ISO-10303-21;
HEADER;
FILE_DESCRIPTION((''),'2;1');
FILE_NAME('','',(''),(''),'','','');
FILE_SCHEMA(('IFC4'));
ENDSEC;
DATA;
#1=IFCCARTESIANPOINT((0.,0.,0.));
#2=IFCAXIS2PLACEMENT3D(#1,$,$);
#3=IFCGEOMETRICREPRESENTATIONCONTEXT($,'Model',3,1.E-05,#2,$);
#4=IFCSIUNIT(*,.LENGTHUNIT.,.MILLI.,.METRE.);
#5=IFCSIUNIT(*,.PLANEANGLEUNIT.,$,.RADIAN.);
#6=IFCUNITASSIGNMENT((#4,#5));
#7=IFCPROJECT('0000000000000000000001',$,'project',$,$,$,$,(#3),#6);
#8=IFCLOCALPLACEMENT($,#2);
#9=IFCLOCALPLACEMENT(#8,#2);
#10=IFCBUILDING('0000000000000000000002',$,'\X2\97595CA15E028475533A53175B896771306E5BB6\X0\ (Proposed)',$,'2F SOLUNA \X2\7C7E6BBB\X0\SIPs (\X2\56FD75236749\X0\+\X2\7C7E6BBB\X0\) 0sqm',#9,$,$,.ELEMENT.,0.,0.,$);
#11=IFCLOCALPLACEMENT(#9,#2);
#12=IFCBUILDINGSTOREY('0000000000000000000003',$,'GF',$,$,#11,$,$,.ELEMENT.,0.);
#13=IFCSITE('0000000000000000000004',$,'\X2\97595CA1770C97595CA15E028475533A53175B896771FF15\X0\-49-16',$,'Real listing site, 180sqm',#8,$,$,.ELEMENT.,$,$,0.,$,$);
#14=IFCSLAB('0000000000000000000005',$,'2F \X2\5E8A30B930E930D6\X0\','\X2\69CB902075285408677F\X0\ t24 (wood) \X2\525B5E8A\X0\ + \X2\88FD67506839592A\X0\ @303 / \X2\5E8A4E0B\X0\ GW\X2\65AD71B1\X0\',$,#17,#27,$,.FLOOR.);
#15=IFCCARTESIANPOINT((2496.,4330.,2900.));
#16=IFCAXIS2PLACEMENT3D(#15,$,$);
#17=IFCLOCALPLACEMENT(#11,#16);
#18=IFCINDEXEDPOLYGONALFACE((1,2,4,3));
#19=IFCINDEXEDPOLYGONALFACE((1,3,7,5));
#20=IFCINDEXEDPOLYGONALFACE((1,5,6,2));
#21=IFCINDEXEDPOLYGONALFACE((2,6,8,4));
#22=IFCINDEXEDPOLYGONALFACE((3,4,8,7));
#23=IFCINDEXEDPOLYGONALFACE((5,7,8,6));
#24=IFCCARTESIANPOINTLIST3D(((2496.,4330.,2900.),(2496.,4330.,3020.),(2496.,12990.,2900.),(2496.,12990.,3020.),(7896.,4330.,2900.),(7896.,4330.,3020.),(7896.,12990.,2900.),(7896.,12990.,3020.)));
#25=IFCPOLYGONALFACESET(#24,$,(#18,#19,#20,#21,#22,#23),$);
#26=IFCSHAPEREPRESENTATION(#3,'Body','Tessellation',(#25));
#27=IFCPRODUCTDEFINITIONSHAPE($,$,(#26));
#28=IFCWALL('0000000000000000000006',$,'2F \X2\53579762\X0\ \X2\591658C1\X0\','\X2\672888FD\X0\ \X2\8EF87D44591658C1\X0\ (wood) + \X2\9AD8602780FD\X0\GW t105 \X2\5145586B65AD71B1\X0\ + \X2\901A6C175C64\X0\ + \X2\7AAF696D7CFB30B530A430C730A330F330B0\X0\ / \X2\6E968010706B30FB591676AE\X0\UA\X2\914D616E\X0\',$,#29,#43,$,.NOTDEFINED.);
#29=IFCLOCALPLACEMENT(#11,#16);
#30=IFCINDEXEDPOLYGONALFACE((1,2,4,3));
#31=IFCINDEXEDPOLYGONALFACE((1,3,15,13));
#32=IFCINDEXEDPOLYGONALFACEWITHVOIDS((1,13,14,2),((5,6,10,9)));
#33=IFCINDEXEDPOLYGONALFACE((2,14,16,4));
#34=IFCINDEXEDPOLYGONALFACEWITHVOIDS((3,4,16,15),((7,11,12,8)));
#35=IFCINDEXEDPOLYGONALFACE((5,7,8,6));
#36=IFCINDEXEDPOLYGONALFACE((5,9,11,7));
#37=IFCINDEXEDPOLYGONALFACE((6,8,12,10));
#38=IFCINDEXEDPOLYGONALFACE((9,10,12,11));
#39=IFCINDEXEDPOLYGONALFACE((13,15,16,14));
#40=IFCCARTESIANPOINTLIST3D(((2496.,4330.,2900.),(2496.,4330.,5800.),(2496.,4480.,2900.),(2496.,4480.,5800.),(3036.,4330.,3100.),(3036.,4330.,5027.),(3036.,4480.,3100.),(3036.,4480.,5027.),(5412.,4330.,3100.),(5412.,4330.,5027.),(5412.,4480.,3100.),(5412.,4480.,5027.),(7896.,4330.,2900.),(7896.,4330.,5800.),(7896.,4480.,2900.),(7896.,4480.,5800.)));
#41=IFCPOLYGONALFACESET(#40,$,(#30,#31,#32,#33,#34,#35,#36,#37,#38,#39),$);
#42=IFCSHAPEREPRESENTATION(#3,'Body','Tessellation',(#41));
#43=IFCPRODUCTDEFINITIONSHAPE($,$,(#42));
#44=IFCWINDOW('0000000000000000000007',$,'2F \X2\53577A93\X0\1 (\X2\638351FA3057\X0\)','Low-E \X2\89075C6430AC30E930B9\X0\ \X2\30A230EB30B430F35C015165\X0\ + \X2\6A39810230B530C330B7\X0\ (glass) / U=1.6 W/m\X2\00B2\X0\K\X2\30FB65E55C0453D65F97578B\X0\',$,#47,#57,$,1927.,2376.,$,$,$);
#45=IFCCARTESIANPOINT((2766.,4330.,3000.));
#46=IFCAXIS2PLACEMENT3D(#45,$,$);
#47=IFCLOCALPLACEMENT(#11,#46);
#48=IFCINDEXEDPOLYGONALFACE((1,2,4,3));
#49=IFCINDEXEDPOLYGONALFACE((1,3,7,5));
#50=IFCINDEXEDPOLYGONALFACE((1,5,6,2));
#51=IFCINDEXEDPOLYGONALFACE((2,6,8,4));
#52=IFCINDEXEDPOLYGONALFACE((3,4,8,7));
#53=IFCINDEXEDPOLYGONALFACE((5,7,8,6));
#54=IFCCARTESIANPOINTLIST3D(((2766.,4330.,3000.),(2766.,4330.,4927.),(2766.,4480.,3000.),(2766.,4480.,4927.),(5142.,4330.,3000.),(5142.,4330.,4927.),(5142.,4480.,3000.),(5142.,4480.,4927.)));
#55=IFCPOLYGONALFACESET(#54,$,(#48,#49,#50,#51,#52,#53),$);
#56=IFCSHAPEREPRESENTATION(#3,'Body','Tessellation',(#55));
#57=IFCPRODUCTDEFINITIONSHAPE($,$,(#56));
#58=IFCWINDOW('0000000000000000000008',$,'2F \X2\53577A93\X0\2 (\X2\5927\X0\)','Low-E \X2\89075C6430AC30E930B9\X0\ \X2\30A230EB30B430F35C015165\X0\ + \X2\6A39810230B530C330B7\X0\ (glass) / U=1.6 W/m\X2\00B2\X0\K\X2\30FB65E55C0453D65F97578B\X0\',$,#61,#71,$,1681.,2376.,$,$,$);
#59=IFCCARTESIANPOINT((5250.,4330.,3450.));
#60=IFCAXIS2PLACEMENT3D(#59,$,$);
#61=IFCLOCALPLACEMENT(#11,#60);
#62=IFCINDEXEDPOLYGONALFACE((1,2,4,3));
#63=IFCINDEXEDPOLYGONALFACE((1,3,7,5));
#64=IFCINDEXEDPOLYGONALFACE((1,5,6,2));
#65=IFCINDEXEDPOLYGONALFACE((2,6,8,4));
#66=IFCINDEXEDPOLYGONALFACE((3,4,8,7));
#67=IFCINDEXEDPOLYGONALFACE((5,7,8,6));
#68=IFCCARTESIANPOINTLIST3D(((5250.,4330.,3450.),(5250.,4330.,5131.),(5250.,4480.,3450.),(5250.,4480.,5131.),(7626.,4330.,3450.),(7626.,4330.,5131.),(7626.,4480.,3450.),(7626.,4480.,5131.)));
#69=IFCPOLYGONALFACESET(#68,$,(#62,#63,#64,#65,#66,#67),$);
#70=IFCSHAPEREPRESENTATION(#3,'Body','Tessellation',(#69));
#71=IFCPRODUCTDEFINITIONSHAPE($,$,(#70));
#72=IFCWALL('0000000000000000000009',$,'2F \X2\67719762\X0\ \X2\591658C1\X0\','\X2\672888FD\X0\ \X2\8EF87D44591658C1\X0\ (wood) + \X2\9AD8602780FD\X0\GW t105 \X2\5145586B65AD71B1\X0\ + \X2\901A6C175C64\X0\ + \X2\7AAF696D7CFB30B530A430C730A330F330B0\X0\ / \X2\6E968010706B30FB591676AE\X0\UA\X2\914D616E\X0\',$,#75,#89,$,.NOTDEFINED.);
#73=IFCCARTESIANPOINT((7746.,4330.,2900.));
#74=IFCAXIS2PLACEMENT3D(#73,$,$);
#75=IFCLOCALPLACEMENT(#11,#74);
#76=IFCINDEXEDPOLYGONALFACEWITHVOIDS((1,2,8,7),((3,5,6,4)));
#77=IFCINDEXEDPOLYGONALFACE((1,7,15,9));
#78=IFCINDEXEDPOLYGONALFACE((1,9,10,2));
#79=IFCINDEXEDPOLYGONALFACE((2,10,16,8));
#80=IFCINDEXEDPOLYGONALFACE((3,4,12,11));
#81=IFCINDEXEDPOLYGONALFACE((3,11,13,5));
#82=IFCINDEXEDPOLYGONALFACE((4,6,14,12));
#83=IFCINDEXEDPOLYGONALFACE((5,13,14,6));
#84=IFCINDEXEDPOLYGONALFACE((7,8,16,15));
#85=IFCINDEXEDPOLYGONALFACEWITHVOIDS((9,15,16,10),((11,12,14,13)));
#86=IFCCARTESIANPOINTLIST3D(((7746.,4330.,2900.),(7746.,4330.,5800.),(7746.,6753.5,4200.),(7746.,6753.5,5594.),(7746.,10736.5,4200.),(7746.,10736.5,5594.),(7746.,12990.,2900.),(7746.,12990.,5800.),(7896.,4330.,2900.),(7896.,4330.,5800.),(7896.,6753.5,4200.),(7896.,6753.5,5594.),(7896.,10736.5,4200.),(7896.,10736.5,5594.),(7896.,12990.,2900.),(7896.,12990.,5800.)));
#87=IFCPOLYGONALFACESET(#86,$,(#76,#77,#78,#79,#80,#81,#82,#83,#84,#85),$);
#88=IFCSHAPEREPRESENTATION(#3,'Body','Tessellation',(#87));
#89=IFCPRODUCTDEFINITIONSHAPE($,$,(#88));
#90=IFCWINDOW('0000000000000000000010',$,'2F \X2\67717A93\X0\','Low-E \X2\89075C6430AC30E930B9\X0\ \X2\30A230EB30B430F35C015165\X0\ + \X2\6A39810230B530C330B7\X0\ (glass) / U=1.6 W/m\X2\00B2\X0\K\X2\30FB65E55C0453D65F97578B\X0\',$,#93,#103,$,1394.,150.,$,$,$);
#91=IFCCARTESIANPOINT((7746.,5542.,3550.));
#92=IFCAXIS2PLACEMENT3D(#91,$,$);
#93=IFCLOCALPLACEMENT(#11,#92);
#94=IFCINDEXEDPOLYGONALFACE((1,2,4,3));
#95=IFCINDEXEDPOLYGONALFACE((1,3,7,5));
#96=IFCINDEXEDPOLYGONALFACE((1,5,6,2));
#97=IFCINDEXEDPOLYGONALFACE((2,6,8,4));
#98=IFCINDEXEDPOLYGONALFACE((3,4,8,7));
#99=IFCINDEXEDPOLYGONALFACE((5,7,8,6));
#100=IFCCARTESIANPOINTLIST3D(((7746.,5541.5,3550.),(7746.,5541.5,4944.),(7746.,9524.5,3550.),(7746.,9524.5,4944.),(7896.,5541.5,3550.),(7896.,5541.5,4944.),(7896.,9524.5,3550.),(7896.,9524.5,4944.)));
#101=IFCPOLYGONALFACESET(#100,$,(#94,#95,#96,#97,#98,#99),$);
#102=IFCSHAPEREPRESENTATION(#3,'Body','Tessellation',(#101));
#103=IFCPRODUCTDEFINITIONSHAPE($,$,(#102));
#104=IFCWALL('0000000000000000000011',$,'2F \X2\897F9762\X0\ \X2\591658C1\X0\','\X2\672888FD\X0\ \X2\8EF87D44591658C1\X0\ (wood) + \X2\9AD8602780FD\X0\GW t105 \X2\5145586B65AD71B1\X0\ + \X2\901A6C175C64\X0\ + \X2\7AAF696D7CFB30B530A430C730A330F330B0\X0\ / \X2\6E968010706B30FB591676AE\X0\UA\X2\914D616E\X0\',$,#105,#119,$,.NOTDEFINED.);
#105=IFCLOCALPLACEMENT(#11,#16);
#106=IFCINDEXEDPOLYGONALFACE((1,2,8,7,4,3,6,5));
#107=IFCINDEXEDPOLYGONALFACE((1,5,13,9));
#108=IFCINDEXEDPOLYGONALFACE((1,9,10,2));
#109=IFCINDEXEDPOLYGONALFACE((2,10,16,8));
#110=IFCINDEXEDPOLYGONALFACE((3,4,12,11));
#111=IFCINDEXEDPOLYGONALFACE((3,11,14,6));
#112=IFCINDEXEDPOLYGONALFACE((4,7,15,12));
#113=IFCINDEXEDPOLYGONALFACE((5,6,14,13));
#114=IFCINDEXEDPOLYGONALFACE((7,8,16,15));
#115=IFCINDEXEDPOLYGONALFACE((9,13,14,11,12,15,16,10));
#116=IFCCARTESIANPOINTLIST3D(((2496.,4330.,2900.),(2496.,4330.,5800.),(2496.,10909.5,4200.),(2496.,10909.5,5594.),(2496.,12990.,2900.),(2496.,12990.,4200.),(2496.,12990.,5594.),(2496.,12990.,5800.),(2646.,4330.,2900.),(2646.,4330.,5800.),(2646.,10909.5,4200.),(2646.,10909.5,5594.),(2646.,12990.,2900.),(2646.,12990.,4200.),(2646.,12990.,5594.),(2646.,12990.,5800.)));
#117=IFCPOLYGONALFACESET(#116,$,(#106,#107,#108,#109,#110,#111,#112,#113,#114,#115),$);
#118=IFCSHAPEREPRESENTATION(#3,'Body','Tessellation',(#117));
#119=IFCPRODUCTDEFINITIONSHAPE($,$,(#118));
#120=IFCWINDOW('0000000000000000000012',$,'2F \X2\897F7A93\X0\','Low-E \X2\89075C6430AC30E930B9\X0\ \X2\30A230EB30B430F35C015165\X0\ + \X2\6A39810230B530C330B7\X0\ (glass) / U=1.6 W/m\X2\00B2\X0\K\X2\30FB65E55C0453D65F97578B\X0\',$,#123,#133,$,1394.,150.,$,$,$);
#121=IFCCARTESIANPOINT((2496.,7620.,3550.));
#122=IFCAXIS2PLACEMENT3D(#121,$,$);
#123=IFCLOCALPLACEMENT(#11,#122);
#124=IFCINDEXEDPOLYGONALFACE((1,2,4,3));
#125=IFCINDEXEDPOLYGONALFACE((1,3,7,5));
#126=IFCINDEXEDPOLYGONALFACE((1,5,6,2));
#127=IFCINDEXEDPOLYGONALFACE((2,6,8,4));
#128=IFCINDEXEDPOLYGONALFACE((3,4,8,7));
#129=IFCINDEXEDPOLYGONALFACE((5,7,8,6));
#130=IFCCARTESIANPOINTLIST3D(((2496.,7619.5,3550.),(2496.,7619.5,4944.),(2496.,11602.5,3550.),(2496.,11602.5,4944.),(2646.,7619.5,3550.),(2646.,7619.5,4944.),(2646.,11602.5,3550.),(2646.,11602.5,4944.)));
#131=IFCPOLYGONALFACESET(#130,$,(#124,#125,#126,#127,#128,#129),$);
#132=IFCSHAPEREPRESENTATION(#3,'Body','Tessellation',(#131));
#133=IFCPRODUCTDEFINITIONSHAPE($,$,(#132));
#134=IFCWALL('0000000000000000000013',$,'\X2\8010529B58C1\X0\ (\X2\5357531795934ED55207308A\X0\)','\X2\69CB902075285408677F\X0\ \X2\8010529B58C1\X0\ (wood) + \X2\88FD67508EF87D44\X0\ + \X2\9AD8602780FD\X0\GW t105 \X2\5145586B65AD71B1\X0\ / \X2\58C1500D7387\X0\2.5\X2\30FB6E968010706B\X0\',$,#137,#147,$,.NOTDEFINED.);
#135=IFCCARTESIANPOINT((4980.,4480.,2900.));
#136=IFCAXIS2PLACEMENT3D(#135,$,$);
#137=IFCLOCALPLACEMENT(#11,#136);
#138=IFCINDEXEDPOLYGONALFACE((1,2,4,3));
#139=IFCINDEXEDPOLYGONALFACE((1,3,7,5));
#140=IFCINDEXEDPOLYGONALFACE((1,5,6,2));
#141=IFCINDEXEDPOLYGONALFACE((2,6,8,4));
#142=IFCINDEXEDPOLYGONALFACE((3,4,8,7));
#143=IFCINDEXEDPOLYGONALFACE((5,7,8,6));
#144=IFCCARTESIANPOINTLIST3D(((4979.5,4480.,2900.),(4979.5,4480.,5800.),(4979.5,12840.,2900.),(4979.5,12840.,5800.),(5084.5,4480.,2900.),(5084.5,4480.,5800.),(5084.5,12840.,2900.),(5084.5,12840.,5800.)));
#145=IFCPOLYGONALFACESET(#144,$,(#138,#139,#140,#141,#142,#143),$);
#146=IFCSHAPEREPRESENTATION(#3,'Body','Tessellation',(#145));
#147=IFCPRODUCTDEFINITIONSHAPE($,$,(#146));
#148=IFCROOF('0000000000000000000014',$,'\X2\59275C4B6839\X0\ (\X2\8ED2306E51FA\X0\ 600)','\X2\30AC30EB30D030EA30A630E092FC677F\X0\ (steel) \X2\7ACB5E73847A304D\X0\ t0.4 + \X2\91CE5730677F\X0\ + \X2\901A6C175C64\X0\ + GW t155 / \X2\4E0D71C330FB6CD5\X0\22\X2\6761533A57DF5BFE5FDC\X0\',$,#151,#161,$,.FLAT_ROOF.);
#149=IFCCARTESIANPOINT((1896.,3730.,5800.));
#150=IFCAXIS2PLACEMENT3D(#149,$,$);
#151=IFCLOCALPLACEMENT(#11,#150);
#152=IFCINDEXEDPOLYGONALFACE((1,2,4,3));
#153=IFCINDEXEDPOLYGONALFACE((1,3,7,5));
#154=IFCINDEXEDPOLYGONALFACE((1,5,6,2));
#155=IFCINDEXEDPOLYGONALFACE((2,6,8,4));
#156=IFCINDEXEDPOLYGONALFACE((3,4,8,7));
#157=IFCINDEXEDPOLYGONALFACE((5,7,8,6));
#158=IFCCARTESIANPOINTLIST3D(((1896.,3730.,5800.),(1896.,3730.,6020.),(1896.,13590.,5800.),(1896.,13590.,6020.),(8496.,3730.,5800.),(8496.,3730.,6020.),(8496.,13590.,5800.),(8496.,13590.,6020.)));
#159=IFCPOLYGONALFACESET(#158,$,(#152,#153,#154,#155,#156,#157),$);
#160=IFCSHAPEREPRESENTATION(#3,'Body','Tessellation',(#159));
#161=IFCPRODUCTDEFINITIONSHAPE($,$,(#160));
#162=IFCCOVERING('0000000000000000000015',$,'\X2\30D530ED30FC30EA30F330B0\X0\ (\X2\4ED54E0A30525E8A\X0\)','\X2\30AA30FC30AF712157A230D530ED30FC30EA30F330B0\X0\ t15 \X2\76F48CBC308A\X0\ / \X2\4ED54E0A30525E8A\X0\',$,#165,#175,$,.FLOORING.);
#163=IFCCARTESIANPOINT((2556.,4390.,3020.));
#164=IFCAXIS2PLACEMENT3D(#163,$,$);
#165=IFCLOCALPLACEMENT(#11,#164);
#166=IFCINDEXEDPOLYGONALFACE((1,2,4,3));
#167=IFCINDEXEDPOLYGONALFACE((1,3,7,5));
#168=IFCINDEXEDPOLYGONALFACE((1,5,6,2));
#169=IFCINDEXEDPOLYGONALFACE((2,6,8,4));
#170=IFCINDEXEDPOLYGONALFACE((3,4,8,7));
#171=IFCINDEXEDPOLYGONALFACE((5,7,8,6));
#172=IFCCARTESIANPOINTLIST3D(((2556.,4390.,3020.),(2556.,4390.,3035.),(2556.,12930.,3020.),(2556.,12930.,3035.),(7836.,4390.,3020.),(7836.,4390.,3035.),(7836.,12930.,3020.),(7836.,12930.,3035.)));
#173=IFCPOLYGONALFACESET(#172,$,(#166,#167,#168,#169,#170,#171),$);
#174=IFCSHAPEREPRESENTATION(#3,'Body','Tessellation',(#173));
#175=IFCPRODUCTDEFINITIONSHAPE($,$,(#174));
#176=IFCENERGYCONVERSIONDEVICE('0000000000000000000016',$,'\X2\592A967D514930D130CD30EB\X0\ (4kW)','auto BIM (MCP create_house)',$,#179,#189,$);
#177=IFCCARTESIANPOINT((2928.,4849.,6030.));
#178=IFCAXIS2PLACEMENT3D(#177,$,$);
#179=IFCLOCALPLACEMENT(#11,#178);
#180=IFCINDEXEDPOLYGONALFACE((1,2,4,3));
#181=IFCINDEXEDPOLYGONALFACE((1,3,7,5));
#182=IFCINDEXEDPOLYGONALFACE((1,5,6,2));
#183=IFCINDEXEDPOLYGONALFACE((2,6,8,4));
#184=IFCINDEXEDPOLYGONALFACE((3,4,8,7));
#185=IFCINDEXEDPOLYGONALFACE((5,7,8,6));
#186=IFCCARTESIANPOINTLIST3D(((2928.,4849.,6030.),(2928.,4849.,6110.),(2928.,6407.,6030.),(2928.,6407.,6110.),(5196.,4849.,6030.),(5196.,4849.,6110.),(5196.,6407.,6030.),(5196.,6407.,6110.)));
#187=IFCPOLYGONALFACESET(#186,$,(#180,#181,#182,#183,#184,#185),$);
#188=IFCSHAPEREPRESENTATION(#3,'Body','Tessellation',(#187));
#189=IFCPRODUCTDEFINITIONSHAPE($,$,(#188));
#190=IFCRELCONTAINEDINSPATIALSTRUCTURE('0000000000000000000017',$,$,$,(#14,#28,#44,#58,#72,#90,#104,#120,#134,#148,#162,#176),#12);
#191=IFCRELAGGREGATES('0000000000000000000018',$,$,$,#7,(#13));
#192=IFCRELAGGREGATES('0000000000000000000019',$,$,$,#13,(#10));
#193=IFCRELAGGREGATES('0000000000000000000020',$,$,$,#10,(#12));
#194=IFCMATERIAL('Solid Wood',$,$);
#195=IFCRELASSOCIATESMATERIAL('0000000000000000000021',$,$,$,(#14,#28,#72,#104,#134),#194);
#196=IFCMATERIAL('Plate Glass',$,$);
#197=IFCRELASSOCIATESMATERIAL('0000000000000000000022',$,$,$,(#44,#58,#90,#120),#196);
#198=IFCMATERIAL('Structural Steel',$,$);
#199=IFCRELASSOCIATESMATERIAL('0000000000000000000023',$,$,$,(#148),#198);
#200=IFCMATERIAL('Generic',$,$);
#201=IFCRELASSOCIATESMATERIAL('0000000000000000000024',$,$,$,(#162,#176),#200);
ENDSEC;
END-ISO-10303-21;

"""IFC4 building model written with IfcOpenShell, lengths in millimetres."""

from ifc_helpers import new_model, si_unit, frame, frame_2d, origin, place, context, project, spatial, rectangle, extrude, material, element, fill, save


model = new_model("IFC4")

# Units and contexts
model_context = context("Model", 3, precision=1e-05, world=origin())
ifc_project = project(units=[si_unit("LENGTHUNIT", "METRE", prefix="MILLI"), si_unit("PLANEANGLEUNIT", "RADIAN")], contexts=[model_context])

# Site, building, storey
site_placement = place(None, origin())
site = spatial("IfcSite", under=ifc_project, at=site_placement, Name="静岡県静岡市葵区北安東５-49-16", ObjectType="Real listing site, 180sqm", CompositionType="ELEMENT", RefElevation=0.0)
building_placement = place(site_placement, origin())
building = spatial("IfcBuilding", under=site, at=building_placement, Name="静岡市葵区北安東の家 (Proposed)", ObjectType="2F SOLUNA 籾殻SIPs (国産杉+籾殻) 0sqm", CompositionType="ELEMENT", ElevationOfRefHeight=0.0, ElevationOfTerrain=0.0)
storey_placement = place(building_placement, origin())
storey = spatial("IfcBuildingStorey", under=building, at=storey_placement, Name="GF", CompositionType="ELEMENT", Elevation=0.0)

# Slab
ifc_material_1 = material(Name="Solid Wood")
slab_placement = place(storey_placement, frame((2496.0, 4330.0, 2900.0)))
element("IfcSlab", 1, at=slab_placement, inside=storey, material=ifc_material_1, Name="2F 床スラブ", Description="構造用合板 t24 (wood) 剛床 + 製材根太 @303 / 床下 GW断熱", PredefinedType="FLOOR", context=model_context, shape_type="SweptSolid", body=[
    extrude(rectangle(XDim=5400.0, YDim=8660.0, at=frame_2d((2700.0, 4330.0))), frame((2496.0, 4330.0, 2900.0)), (0.0, 0.0, 1.0), 120.0),
])

# Wall, openings, windows
wall_1_placement = place(storey_placement, frame((2496.0, 4330.0, 2900.0)))
wall_1 = element("IfcWall", 2, at=wall_1_placement, inside=storey, material=ifc_material_1, Name="2F 南面 外壁", Description="木製 軸組外壁 (wood) + 高性能GW t105 充填断熱 + 通気層 + 窯業系サイディング / 準耐火・外皮UA配慮", PredefinedType="NOTDEFINED", context=model_context, shape_type="SweptSolid", body=[
    extrude(rectangle(XDim=5400.0, YDim=150.0, at=frame_2d((2700.0, 75.0))), frame((2496.0, 4330.0, 2900.0)), (0.0, 0.0, 1.0), 2900.0),
])
opening_1_placement = place(storey_placement, frame((2766.0, 4330.0, 3000.0)))
opening_1 = element("IfcOpeningElement", 3, at=opening_1_placement, cuts=wall_1, PredefinedType="NOTDEFINED", context=model_context, shape_type="SweptSolid", body=[
    extrude(rectangle(XDim=2376.0, YDim=150.0, at=frame_2d((1188.0, 75.0))), frame((2766.0, 4330.0, 3000.0)), (0.0, 0.0, 1.0), 1927.0),
])
opening_2_placement = place(storey_placement, frame((5250.0, 4330.0, 3450.0)))
opening_2 = element("IfcOpeningElement", 4, at=opening_2_placement, cuts=wall_1, PredefinedType="NOTDEFINED", context=model_context, shape_type="SweptSolid", body=[
    extrude(rectangle(XDim=2376.0, YDim=150.0, at=frame_2d((1188.0, 75.0))), frame((5250.0, 4330.0, 3450.0)), (0.0, 0.0, 1.0), 1681.0),
])
ifc_material_2 = material(Name="Plate Glass")
window_1_placement = place(storey_placement, frame((2766.0, 4330.0, 3000.0)))
window_1 = element("IfcWindow", 5, at=window_1_placement, inside=storey, material=ifc_material_2, Name="2F 南窓1 (掃出し)", Description="Low-E 複層ガラス アルゴン封入 + 樹脂サッシ (glass) / U=1.6 W/m²K・日射取得型", OverallHeight=1927.0, OverallWidth=2376.0, context=model_context, shape_type="SweptSolid", body=[
    extrude(rectangle(XDim=2376.0, YDim=150.0, at=frame_2d((1188.0, 75.0))), frame((2766.0, 4330.0, 3000.0)), (0.0, 0.0, 1.0), 1927.0),
])
fill(opening_1, window_1)
window_2_placement = place(storey_placement, frame((5250.0, 4330.0, 3450.0)))
window_2 = element("IfcWindow", 6, at=window_2_placement, inside=storey, material=ifc_material_2, Name="2F 南窓2 (大)", Description="Low-E 複層ガラス アルゴン封入 + 樹脂サッシ (glass) / U=1.6 W/m²K・日射取得型", OverallHeight=1681.0, OverallWidth=2376.0, context=model_context, shape_type="SweptSolid", body=[
    extrude(rectangle(XDim=2376.0, YDim=150.0, at=frame_2d((1188.0, 75.0))), frame((5250.0, 4330.0, 3450.0)), (0.0, 0.0, 1.0), 1681.0),
])
fill(opening_2, window_2)

# Walls, openings, windows
wall_2_placement = place(storey_placement, frame((7746.0, 4330.0, 2900.0)))
wall_2 = element("IfcWall", 7, at=wall_2_placement, inside=storey, material=ifc_material_1, Name="2F 東面 外壁", Description="木製 軸組外壁 (wood) + 高性能GW t105 充填断熱 + 通気層 + 窯業系サイディング / 準耐火・外皮UA配慮", PredefinedType="NOTDEFINED", context=model_context, shape_type="SweptSolid", body=[
    extrude(rectangle(XDim=150.0, YDim=8660.0, at=frame_2d((75.0, 4330.0))), frame((7746.0, 4330.0, 2900.0)), (0.0, 0.0, 1.0), 2900.0),
])
opening_3_placement = place(storey_placement, frame((7746.0, 5542.0, 3550.0)))
opening_3 = element("IfcOpeningElement", 8, at=opening_3_placement, cuts=wall_2, PredefinedType="NOTDEFINED", context=model_context, shape_type="SweptSolid", body=[
    extrude(rectangle(XDim=150.0, YDim=3983.0, at=frame_2d((75.0, 1991.0))), frame((7746.0, 5542.0, 3550.0)), (0.0, 0.0, 1.0), 1394.0),
])
window_3_placement = place(storey_placement, frame((7746.0, 5542.0, 3550.0)))
window_3 = element("IfcWindow", 9, at=window_3_placement, inside=storey, material=ifc_material_2, Name="2F 東窓", Description="Low-E 複層ガラス アルゴン封入 + 樹脂サッシ (glass) / U=1.6 W/m²K・日射取得型", OverallHeight=1394.0, OverallWidth=150.0, context=model_context, shape_type="SweptSolid", body=[
    extrude(rectangle(XDim=150.0, YDim=3983.0, at=frame_2d((75.0, 1991.0))), frame((7746.0, 5542.0, 3550.0)), (0.0, 0.0, 1.0), 1394.0),
])
fill(opening_3, window_3)
wall_3_placement = place(storey_placement, frame((2496.0, 4330.0, 2900.0)))
wall_3 = element("IfcWall", 10, at=wall_3_placement, inside=storey, material=ifc_material_1, Name="2F 西面 外壁", Description="木製 軸組外壁 (wood) + 高性能GW t105 充填断熱 + 通気層 + 窯業系サイディング / 準耐火・外皮UA配慮", PredefinedType="NOTDEFINED", context=model_context, shape_type="SweptSolid", body=[
    extrude(rectangle(XDim=150.0, YDim=8660.0, at=frame_2d((75.0, 4330.0))), frame((2496.0, 4330.0, 2900.0)), (0.0, 0.0, 1.0), 2900.0),
])
opening_4_placement = place(storey_placement, frame((2496.0, 7620.0, 3550.0)))
opening_4 = element("IfcOpeningElement", 11, at=opening_4_placement, cuts=wall_3, PredefinedType="NOTDEFINED", context=model_context, shape_type="SweptSolid", body=[
    extrude(rectangle(XDim=150.0, YDim=3983.0, at=frame_2d((75.0, 1991.0))), frame((2496.0, 7620.0, 3550.0)), (0.0, 0.0, 1.0), 1394.0),
])
window_4_placement = place(storey_placement, frame((2496.0, 7620.0, 3550.0)))
window_4 = element("IfcWindow", 12, at=window_4_placement, inside=storey, material=ifc_material_2, Name="2F 西窓", Description="Low-E 複層ガラス アルゴン封入 + 樹脂サッシ (glass) / U=1.6 W/m²K・日射取得型", OverallHeight=1394.0, OverallWidth=150.0, context=model_context, shape_type="SweptSolid", body=[
    extrude(rectangle(XDim=150.0, YDim=3983.0, at=frame_2d((75.0, 1991.0))), frame((2496.0, 7620.0, 3550.0)), (0.0, 0.0, 1.0), 1394.0),
])
fill(opening_4, window_4)

# Wall
wall_4_placement = place(storey_placement, frame((4980.0, 4480.0, 2900.0)))
element("IfcWall", 13, at=wall_4_placement, inside=storey, material=ifc_material_1, Name="耐力壁 (南北間仕切り)", Description="構造用合板 耐力壁 (wood) + 製材軸組 + 高性能GW t105 充填断熱 / 壁倍率2.5・準耐火", PredefinedType="NOTDEFINED", context=model_context, shape_type="SweptSolid", body=[
    extrude(rectangle(XDim=105.0, YDim=8360.0, at=frame_2d((52.0, 4180.0))), frame((4980.0, 4480.0, 2900.0)), (0.0, 0.0, 1.0), 2900.0),
])

# Roof
ifc_material_3 = material(Name="Structural Steel")
roof_placement = place(storey_placement, frame((1896.0, 3730.0, 5800.0)))
element("IfcRoof", 14, at=roof_placement, inside=storey, material=ifc_material_3, Name="大屋根 (軒の出 600)", Description="ガルバリウム鋼板 (steel) 立平葺き t0.4 + 野地板 + 通気層 + GW t155 / 不燃・法22条区域対応", PredefinedType="FLAT_ROOF", context=model_context, shape_type="SweptSolid", body=[
    extrude(rectangle(XDim=6600.0, YDim=9860.0, at=frame_2d((3300.0, 4930.0))), frame((1896.0, 3730.0, 5800.0)), (0.0, 0.0, 1.0), 220.0),
])

# Covering
ifc_material_4 = material(Name="Generic")
covering_placement = place(storey_placement, frame((2556.0, 4390.0, 3020.0)))
element("IfcCovering", 15, at=covering_placement, inside=storey, material=ifc_material_4, Name="フローリング (仕上げ床)", Description="オーク無垢フローリング t15 直貼り / 仕上げ床", PredefinedType="FLOORING", context=model_context, shape_type="SweptSolid", body=[
    extrude(rectangle(XDim=5280.0, YDim=8540.0, at=frame_2d((2640.0, 4270.0))), frame((2556.0, 4390.0, 3020.0)), (0.0, 0.0, 1.0), 15.0),
])

# Energy conversion device
energy_conversion_device_placement = place(storey_placement, frame((2928.0, 4849.0, 6030.0)))
element("IfcEnergyConversionDevice", 16, at=energy_conversion_device_placement, inside=storey, material=ifc_material_4, Name="太陽光パネル (4kW)", Description="auto BIM (MCP create_house)", context=model_context, shape_type="SweptSolid", body=[
    extrude(rectangle(XDim=2268.0, YDim=1558.0, at=frame_2d((1134.0, 779.0))), frame((2928.0, 4849.0, 6030.0)), (0.0, 0.0, 1.0), 80.0),
])

save(model, "model.ifc")
